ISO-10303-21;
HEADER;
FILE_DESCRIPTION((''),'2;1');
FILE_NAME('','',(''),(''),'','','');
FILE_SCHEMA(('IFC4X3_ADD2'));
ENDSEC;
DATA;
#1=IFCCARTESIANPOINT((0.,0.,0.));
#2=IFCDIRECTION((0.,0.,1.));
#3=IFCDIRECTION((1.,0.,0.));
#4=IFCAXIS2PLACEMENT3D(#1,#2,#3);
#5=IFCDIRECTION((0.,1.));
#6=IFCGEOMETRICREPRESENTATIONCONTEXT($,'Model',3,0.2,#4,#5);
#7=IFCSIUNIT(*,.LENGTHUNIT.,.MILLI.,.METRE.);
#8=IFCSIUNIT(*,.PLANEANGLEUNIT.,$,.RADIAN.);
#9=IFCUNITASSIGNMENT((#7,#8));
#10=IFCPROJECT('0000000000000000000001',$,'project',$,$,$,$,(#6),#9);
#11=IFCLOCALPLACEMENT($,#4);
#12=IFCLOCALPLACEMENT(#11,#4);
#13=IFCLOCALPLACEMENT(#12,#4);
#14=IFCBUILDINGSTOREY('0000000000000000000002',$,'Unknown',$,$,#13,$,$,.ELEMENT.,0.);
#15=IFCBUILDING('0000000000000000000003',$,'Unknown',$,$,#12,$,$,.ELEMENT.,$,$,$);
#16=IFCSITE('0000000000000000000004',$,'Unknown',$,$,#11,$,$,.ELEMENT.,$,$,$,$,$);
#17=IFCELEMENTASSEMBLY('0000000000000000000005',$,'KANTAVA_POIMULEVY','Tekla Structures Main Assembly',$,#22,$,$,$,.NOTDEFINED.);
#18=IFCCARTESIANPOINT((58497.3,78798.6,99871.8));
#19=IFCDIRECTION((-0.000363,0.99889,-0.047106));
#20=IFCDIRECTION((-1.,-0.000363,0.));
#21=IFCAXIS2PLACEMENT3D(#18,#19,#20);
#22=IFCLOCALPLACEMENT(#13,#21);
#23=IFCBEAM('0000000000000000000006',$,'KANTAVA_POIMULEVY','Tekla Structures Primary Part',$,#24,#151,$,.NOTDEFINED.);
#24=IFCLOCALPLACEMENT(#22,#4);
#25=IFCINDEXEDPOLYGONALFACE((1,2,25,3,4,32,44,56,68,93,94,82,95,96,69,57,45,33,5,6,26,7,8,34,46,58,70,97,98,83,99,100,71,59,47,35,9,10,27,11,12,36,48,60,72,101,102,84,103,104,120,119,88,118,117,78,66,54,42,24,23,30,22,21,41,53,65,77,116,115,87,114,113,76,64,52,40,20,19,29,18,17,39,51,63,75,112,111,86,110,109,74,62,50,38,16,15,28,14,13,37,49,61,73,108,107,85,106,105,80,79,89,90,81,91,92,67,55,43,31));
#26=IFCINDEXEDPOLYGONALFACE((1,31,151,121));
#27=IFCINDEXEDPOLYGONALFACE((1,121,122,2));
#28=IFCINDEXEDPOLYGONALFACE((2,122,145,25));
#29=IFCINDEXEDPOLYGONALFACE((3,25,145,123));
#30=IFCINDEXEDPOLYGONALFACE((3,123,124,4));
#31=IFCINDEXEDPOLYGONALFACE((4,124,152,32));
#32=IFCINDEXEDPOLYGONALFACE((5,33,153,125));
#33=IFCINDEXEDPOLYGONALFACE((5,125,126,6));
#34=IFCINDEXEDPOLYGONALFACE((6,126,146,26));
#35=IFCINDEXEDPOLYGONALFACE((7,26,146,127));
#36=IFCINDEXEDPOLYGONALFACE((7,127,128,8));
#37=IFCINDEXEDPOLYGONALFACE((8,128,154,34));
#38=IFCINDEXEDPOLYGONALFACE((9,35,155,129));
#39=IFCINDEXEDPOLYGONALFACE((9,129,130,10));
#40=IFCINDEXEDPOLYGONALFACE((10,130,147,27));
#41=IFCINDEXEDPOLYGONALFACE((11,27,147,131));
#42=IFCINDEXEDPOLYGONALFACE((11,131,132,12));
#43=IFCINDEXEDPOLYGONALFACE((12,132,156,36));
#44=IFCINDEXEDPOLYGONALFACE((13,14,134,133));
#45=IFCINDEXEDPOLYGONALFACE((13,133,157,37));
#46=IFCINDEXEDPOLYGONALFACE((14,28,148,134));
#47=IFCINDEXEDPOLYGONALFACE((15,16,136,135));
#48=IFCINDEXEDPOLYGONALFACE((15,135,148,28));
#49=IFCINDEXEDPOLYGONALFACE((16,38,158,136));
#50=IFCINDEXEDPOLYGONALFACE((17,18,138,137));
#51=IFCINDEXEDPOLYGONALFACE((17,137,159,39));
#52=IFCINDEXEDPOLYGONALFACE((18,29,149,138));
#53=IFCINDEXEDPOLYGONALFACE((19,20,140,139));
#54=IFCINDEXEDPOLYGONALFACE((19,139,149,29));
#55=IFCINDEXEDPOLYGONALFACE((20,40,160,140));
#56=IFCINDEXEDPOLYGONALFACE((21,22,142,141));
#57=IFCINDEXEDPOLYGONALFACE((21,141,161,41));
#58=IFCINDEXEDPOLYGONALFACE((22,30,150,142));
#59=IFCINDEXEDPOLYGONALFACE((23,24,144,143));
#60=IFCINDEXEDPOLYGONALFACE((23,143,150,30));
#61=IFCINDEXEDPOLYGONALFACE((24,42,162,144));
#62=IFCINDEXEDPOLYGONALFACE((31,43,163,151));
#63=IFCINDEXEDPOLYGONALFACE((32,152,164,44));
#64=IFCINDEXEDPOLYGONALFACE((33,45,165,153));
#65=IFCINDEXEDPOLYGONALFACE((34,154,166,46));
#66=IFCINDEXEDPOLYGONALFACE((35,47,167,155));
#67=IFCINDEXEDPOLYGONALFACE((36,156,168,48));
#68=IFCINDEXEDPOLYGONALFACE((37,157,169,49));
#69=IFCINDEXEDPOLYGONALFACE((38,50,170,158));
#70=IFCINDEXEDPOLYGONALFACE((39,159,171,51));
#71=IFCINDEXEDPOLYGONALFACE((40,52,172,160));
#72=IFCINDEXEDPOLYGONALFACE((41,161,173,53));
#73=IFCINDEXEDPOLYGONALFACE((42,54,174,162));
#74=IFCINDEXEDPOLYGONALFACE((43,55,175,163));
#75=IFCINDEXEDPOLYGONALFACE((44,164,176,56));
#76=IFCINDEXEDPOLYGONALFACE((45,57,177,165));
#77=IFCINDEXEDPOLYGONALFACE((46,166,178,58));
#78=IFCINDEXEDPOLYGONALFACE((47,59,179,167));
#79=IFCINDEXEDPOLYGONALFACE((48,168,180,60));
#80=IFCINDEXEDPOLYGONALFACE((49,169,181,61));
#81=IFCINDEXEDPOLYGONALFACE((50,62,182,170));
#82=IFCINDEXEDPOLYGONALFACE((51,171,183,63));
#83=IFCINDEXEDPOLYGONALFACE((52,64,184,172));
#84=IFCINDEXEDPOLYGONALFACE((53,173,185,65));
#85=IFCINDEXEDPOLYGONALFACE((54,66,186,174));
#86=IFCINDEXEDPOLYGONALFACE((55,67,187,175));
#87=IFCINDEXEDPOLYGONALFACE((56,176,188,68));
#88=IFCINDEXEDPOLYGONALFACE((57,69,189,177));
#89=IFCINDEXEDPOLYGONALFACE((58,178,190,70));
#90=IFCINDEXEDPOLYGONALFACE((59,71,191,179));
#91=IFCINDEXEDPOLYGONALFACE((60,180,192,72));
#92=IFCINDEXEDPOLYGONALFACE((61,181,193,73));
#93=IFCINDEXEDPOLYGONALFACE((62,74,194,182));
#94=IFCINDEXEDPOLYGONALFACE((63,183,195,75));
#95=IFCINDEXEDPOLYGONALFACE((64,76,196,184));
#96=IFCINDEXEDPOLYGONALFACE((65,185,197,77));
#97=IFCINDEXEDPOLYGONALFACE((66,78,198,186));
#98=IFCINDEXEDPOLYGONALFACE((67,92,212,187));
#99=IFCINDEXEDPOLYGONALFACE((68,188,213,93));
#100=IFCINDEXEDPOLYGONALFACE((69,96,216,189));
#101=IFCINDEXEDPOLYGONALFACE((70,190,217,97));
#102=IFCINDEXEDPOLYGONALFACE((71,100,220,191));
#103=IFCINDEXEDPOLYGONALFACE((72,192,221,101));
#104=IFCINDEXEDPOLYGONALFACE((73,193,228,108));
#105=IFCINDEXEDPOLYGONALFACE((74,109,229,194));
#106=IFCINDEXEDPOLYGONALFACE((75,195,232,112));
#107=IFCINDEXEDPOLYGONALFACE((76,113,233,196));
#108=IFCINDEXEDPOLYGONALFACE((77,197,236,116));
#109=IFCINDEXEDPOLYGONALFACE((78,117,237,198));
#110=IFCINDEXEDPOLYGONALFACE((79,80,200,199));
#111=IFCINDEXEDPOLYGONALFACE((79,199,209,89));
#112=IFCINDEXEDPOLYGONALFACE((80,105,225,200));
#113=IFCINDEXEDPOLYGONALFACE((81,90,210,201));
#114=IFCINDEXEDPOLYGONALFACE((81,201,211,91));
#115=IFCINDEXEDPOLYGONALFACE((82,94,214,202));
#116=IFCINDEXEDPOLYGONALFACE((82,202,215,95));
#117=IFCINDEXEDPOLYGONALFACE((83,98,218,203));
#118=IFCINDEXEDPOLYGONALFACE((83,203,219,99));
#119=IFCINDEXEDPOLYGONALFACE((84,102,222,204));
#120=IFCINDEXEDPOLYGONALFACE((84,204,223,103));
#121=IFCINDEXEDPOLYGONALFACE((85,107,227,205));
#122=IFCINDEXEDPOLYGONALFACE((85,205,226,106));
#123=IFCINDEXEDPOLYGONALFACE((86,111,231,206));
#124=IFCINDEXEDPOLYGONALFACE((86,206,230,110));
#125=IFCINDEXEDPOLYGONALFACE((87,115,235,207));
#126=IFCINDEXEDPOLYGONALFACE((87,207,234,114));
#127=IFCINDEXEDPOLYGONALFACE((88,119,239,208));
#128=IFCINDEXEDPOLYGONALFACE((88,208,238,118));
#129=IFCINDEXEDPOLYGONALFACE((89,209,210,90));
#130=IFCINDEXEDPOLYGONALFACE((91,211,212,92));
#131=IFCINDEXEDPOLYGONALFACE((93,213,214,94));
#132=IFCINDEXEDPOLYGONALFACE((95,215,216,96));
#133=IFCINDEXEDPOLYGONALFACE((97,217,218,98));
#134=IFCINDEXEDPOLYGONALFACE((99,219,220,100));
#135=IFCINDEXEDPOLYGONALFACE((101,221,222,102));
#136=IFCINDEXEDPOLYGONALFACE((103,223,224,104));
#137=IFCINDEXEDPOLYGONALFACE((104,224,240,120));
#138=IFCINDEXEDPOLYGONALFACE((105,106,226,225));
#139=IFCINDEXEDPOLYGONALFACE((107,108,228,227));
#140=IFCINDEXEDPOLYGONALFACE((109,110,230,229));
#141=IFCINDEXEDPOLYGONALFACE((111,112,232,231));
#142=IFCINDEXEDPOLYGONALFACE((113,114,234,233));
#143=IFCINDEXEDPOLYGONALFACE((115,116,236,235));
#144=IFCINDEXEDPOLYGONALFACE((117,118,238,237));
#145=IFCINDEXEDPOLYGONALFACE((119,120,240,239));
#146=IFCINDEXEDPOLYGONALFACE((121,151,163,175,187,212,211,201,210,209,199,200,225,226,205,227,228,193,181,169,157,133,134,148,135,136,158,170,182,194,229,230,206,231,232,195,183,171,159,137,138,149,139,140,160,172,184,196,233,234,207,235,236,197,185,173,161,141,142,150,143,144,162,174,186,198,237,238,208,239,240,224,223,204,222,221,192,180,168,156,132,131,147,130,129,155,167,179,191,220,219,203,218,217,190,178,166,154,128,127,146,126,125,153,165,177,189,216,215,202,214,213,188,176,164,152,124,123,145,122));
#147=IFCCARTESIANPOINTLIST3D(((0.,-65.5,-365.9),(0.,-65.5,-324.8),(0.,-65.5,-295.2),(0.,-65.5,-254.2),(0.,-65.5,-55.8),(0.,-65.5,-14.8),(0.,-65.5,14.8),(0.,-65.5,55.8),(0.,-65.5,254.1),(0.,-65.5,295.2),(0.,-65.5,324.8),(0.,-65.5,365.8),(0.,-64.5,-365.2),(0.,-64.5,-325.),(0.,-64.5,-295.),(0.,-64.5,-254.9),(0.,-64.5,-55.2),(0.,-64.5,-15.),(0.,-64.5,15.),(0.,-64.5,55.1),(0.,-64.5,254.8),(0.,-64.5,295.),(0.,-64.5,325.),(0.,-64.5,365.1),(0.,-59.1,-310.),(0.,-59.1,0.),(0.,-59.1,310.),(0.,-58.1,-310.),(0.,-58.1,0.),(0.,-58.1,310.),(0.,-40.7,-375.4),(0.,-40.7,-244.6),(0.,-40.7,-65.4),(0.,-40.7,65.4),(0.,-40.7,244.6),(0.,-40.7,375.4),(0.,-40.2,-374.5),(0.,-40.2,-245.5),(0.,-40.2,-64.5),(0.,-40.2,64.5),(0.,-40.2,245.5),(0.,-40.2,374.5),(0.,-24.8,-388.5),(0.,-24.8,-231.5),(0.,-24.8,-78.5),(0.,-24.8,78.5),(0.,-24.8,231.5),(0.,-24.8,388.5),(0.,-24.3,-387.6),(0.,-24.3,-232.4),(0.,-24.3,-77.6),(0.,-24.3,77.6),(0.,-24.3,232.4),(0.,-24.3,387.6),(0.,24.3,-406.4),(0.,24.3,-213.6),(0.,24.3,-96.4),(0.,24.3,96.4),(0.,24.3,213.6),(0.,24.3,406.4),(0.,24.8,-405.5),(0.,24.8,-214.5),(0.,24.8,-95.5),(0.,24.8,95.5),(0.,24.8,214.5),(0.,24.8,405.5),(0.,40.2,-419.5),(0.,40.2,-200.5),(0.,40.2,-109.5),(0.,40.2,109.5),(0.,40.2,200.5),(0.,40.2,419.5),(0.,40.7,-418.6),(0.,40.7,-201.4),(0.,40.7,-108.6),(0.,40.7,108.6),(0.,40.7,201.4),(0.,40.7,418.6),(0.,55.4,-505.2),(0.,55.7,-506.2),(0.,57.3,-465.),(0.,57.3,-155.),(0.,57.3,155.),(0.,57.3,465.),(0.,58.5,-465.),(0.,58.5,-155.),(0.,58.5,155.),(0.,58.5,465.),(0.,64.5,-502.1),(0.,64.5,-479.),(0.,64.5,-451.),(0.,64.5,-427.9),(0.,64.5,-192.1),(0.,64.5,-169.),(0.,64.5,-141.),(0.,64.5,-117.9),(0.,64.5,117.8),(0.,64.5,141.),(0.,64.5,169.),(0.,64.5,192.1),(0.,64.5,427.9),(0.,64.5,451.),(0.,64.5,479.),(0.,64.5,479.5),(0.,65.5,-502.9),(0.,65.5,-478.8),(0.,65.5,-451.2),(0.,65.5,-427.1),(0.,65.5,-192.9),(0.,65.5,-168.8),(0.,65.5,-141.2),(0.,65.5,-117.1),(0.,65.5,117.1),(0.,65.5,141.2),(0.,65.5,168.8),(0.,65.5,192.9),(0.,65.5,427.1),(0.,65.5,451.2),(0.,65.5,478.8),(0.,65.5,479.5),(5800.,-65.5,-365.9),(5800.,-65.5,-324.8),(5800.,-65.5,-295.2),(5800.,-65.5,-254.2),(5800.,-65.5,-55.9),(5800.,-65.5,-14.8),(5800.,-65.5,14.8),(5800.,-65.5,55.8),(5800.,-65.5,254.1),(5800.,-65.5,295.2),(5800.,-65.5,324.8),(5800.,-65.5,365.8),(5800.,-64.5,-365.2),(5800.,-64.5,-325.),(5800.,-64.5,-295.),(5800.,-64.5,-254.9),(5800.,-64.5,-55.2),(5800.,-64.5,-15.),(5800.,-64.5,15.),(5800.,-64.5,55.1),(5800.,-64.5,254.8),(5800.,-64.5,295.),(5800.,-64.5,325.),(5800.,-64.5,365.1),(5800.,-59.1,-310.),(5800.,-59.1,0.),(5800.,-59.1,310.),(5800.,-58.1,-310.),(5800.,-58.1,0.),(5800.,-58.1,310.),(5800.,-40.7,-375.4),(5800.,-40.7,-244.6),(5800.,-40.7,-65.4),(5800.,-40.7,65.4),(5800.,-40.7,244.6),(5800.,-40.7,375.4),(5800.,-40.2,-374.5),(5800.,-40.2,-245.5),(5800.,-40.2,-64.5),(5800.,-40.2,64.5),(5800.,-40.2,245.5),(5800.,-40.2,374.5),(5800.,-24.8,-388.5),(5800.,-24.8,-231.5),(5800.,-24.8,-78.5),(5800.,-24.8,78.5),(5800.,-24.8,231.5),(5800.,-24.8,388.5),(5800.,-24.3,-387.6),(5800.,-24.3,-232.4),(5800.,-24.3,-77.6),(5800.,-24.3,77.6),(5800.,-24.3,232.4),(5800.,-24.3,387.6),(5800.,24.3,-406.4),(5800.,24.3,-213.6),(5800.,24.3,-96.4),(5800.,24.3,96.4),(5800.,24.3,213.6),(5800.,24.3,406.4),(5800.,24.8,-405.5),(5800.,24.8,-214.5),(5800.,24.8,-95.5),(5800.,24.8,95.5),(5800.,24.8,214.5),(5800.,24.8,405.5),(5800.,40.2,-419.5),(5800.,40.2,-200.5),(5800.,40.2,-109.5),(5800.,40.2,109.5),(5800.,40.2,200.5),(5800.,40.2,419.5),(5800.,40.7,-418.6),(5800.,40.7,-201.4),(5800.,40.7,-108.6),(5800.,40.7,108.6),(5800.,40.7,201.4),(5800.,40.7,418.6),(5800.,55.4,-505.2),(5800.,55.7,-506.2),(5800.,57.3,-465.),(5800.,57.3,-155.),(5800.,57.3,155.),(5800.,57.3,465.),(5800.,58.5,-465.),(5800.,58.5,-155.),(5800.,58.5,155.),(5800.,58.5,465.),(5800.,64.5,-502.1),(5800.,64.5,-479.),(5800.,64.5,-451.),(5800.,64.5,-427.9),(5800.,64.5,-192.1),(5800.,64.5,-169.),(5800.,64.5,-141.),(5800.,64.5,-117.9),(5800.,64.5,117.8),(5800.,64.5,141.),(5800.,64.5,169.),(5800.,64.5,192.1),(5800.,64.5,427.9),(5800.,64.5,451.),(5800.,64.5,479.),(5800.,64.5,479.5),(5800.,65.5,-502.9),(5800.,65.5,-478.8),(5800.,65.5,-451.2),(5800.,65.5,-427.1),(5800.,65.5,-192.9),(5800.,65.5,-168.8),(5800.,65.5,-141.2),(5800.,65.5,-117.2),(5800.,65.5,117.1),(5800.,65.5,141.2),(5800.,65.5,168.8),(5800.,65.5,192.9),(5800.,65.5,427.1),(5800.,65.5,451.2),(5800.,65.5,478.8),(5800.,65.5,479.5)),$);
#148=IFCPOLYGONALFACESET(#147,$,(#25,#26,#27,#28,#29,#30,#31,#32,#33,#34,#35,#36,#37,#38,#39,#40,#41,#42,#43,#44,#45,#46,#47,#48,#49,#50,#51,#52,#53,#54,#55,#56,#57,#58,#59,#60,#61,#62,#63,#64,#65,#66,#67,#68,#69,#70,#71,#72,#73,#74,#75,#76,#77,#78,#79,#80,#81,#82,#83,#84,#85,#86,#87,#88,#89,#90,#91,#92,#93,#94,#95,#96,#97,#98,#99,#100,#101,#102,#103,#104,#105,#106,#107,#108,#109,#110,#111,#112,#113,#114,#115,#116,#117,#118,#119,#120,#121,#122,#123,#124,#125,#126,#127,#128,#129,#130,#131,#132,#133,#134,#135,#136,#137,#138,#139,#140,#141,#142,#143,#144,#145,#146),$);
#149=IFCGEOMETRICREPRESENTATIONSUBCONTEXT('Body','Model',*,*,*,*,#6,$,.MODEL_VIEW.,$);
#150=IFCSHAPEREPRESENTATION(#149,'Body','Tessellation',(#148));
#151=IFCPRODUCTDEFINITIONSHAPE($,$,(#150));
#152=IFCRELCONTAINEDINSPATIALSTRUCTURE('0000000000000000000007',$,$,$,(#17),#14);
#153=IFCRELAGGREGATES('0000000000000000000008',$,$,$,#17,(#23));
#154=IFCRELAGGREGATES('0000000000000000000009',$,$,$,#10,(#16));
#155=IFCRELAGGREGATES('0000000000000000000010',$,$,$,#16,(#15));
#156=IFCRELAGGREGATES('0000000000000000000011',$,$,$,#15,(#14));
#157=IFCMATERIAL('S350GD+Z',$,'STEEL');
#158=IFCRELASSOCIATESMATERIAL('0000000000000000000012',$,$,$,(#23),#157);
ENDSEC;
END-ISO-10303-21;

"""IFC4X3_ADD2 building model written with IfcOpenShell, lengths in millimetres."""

from ifc_helpers import new_model, si_unit, direction, frame, origin_with_axes, place, context, subcontext, project, spatial, line, indexed_curve, outline, extrude, material, element, aggregate, save


model = new_model("IFC4X3_ADD2")

# Units and contexts
model_context = context("Model", 3, precision=0.2, world=origin_with_axes(), true_north=direction((0.0, 1.0)))
body_context = subcontext(model_context, "Body", "Model", "MODEL_VIEW")
ifc_project = project(units=[si_unit("LENGTHUNIT", "METRE", prefix="MILLI"), si_unit("PLANEANGLEUNIT", "RADIAN")], contexts=[model_context])

# Site, building, storey
site_placement = place(None, origin_with_axes())
site = spatial("IfcSite", under=ifc_project, at=site_placement, Name="Unknown", CompositionType="ELEMENT")
building_placement = place(site_placement, origin_with_axes())
building = spatial("IfcBuilding", under=site, at=building_placement, Name="Unknown", CompositionType="ELEMENT")
storey_placement = place(building_placement, origin_with_axes())
storey = spatial("IfcBuildingStorey", under=building, at=storey_placement, Name="Unknown", CompositionType="ELEMENT", Elevation=0.0)

# Element assembly, beam
ifc_material_1 = material(Name="S350GD+Z", Category="STEEL")
assembly_1_placement = place(storey_placement, frame((58497.3, 78798.6, 99871.8), z_axis=(-0.000363, 0.99889, -0.047106), x_axis=(-1.0, -0.000363, 0.0)))
assembly_1 = element("IfcElementAssembly", 1, at=assembly_1_placement, inside=storey, Name="KANTAVA_POIMULEVY", Description="Tekla Structures Main Assembly", PredefinedType="NOTDEFINED")
beam_1_placement = place(assembly_1_placement, origin_with_axes())
beam_1 = element("IfcBeam", 2, at=beam_1_placement, material=ifc_material_1, Name="KANTAVA_POIMULEVY", Description="Tekla Structures Primary Part", PredefinedType="NOTDEFINED", context=body_context, shape_type="SolidModel", body=[
    extrude(outline(indexed_curve([(479.5, 65.5), (478.8, 65.5), (465.0, 58.5), (451.2, 65.5), (427.1, 65.5), (418.6, 40.7), (405.5, 24.8), (387.6, -24.3), (374.5, -40.2), (365.1, -64.5), (325.0, -64.5), (310.0, -58.1), (295.0, -64.5), (254.8, -64.5), (245.5, -40.2), (232.4, -24.3), (214.5, 24.8), (201.4, 40.7), (192.9, 65.5), (168.8, 65.5), (155.0, 58.5), (141.2, 65.5), (117.1, 65.5), (108.6, 40.7), (95.5, 24.8), (77.6, -24.3), (64.5, -40.2), (55.1, -64.5), (15.0, -64.5), (0.0, -58.1), (-15.0, -64.5), (-55.2, -64.5), (-64.5, -40.2), (-77.6, -24.3), (-95.5, 24.8), (-108.6, 40.7), (-117.2, 65.5), (-141.2, 65.5), (-155.0, 58.5), (-168.8, 65.5), (-192.9, 65.5), (-201.4, 40.7), (-214.5, 24.8), (-232.4, -24.3), (-245.5, -40.2), (-254.9, -64.5), (-295.0, -64.5), (-310.0, -58.1), (-325.0, -64.5), (-365.2, -64.5), (-374.5, -40.2), (-387.6, -24.3), (-405.5, 24.8), (-418.6, 40.7), (-427.1, 65.5), (-451.2, 65.5), (-465.0, 58.5), (-478.8, 65.5), (-502.9, 65.5), (-506.2, 55.7), (-505.2, 55.4), (-502.1, 64.5), (-479.0, 64.5), (-465.0, 57.3), (-451.0, 64.5), (-427.9, 64.5), (-419.5, 40.2), (-406.4, 24.3), (-388.5, -24.8), (-375.4, -40.7), (-365.9, -65.5), (-324.8, -65.5), (-310.0, -59.1), (-295.2, -65.5), (-254.2, -65.5), (-244.6, -40.7), (-231.5, -24.8), (-213.6, 24.3), (-200.5, 40.2), (-192.1, 64.5), (-169.0, 64.5), (-155.0, 57.3), (-141.0, 64.5), (-117.9, 64.5), (-109.5, 40.2), (-96.4, 24.3), (-78.5, -24.8), (-65.4, -40.7), (-55.9, -65.5), (-14.8, -65.5), (0.0, -59.1), (14.8, -65.5), (55.8, -65.5), (65.4, -40.7), (78.5, -24.8), (96.4, 24.3), (109.5, 40.2), (117.8, 64.5), (141.0, 64.5), (155.0, 57.3), (169.0, 64.5), (192.1, 64.5), (200.5, 40.2), (213.6, 24.3), (231.5, -24.8), (244.6, -40.7), (254.1, -65.5), (295.2, -65.5), (310.0, -59.1), (324.8, -65.5), (365.8, -65.5), (375.4, -40.7), (388.5, -24.8), (406.4, 24.3), (419.5, 40.2), (427.9, 64.5), (451.0, 64.5), (465.0, 57.3), (479.0, 64.5), (479.5, 64.5)], segments=[line(1, 2, 3, 4, 5, 6, 7, 8, 9, 10, 11, 12, 13, 14, 15, 16, 17, 18, 19, 20, 21, 22, 23, 24, 25, 26, 27, 28, 29, 30, 31, 32, 33, 34, 35, 36, 37, 38, 39, 40, 41, 42, 43, 44, 45, 46, 47, 48, 49, 50, 51, 52, 53, 54, 55, 56, 57, 58, 59, 60, 61, 62, 63, 64, 65, 66, 67, 68, 69, 70, 71, 72, 73, 74, 75, 76, 77, 78, 79, 80, 81, 82, 83, 84, 85, 86, 87, 88, 89, 90, 91, 92, 93, 94, 95, 96, 97, 98, 99, 100, 101, 102, 103, 104, 105, 106, 107, 108, 109, 110, 111, 112, 113, 114, 115, 116, 117, 118, 119, 120, 1)])), frame((0.0, 0.0, 0.0), z_axis=(-1.0, 0.0, 0.0), x_axis=(0.0, 0.0, 1.0)), (0.0, 0.0, -1.0), 5800.0),
])
aggregate(assembly_1, [beam_1])

save(model, "model.ifc")
